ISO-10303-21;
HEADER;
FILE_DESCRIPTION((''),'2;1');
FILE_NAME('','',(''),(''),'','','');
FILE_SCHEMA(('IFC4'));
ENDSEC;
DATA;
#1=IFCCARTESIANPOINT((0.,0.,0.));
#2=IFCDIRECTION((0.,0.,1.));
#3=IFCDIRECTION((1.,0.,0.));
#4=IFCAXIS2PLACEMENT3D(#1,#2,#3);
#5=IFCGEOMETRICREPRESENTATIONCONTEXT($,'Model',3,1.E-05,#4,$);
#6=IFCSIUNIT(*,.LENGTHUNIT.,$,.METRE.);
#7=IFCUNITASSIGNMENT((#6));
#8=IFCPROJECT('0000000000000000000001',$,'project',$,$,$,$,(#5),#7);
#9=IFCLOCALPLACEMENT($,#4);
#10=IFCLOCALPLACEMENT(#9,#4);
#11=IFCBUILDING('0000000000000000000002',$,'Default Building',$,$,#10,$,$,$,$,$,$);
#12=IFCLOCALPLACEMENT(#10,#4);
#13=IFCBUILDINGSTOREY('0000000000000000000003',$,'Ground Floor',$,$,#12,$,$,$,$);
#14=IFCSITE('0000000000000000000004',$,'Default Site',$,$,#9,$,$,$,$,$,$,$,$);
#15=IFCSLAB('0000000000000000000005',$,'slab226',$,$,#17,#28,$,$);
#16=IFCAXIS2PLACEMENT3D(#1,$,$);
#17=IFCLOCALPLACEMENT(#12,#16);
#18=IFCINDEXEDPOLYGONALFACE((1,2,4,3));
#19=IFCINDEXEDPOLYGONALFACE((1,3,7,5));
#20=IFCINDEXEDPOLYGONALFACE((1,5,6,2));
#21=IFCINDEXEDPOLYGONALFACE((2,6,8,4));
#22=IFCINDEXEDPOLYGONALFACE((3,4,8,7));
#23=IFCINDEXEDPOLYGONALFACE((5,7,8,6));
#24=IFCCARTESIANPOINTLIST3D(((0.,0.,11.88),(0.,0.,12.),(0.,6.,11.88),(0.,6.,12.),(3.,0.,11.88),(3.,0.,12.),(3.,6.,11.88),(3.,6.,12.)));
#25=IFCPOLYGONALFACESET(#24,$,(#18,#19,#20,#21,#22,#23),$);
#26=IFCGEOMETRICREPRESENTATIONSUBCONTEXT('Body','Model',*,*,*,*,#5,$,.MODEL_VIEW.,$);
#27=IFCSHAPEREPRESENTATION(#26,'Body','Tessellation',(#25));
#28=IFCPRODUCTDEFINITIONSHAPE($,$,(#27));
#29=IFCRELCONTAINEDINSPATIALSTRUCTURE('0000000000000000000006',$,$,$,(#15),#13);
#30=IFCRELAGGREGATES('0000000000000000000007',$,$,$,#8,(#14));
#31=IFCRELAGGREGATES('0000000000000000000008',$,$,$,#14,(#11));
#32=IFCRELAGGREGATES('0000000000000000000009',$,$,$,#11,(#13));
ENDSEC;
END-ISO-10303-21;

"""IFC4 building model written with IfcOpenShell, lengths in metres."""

from ifc_helpers import new_model, si_unit, frame, origin_with_axes, place, context, subcontext, project, spatial, indexed_curve, outline, extrude, element, save


model = new_model("IFC4")

# Units and contexts
model_context = context("Model", 3, precision=1e-05, world=origin_with_axes())
body_context = subcontext(model_context, "Body", "Model", "MODEL_VIEW")
ifc_project = project(units=[si_unit("LENGTHUNIT", "METRE")], contexts=[model_context])

# Site, building, storey
site_placement = place(None, origin_with_axes())
site = spatial("IfcSite", under=ifc_project, at=site_placement, Name="Default Site")
building_placement = place(site_placement, origin_with_axes())
building = spatial("IfcBuilding", under=site, at=building_placement, Name="Default Building")
storey_placement = place(building_placement, origin_with_axes())
storey = spatial("IfcBuildingStorey", under=building, at=storey_placement, Name="Ground Floor")

# Slab
for number, where, z_axis, x_axis, name in (
    (1, (0.0, 0.0, 11.88), (0.0, 0.0, 1.0), (1.0, 0.0, 0.0), "slab226"),
):
    element("IfcSlab", number, at=place(storey_placement, frame(where, z_axis=z_axis, x_axis=x_axis)), inside=storey, Name=name, context=body_context, shape_type="SweptSolid", body=[
        extrude(outline(indexed_curve([(0.0, 0.0), (0.0, 6.0), (3.0, 6.0), (3.0, 0.0), (0.0, 0.0)], self_intersect=False)), origin_with_axes(), (0.0, 0.0, 1.0), 0.12),
    ])

save(model, "model.ifc")
